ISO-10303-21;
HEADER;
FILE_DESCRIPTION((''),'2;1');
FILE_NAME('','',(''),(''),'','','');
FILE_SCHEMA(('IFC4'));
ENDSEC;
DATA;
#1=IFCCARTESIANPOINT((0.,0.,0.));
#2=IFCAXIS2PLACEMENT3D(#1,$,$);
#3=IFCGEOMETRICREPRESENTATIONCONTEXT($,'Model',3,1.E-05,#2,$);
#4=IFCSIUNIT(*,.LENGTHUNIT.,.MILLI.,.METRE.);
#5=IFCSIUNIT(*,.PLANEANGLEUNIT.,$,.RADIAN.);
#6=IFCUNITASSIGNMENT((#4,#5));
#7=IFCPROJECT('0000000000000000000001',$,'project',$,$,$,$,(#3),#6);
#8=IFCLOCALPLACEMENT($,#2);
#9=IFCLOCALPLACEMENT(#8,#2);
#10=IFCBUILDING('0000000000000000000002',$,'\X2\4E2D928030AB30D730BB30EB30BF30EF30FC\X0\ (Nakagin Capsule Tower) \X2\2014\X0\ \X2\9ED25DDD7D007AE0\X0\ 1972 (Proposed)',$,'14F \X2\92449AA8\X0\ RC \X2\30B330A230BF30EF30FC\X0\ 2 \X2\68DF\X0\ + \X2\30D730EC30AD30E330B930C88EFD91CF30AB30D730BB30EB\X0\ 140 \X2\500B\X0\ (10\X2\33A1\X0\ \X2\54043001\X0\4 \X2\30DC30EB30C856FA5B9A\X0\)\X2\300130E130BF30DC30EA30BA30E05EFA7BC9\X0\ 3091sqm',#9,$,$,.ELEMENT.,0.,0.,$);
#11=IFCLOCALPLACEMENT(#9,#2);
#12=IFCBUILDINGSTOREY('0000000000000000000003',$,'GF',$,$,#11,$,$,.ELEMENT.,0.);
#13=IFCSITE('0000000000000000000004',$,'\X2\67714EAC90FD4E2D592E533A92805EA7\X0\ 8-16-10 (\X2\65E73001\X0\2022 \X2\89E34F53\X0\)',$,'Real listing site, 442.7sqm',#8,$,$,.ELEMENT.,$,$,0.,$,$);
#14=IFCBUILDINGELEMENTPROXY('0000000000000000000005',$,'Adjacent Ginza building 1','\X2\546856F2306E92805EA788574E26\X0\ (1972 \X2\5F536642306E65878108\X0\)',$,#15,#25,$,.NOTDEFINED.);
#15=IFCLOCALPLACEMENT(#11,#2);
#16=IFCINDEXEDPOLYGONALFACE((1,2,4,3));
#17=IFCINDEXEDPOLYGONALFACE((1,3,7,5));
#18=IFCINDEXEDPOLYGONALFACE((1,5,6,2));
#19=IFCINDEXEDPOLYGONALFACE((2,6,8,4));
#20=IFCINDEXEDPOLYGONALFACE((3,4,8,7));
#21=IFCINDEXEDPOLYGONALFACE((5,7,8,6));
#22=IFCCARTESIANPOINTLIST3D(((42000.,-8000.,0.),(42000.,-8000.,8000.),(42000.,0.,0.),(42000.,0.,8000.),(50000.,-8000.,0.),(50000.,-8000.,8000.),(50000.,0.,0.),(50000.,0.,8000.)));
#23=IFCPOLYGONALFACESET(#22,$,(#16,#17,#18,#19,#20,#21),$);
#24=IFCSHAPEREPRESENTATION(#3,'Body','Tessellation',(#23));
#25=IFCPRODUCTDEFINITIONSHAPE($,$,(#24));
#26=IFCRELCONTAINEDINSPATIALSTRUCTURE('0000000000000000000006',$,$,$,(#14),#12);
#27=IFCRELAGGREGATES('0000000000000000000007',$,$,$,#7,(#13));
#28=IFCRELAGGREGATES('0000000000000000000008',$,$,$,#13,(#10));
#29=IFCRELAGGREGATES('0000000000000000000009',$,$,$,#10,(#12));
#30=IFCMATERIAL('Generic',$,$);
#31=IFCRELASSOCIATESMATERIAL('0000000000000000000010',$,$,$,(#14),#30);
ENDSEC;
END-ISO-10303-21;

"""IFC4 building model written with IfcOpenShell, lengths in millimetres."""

from ifc_helpers import new_model, si_unit, frame, frame_2d, origin, place, context, project, spatial, rectangle, extrude, material, element, save


model = new_model("IFC4")

# Units and contexts
model_context = context("Model", 3, precision=1e-05, world=origin())
ifc_project = project(units=[si_unit("LENGTHUNIT", "METRE", prefix="MILLI"), si_unit("PLANEANGLEUNIT", "RADIAN")], contexts=[model_context])

# Site, building, storey
site_placement = place(None, origin())
site = spatial("IfcSite", under=ifc_project, at=site_placement, Name="東京都中央区銀座 8-16-10 (旧、2022 解体)", ObjectType="Real listing site, 442.7sqm", CompositionType="ELEMENT", RefElevation=0.0)
building_placement = place(site_placement, origin())
building = spatial("IfcBuilding", under=site, at=building_placement, Name="中銀カプセルタワー (Nakagin Capsule Tower) — 黒川紀章 1972 (Proposed)", ObjectType="14F 鉄骨 RC コアタワー 2 棟 + プレキャスト軽量カプセル 140 個 (10㎡ 各、4 ボルト固定)、メタボリズム建築 3091sqm", CompositionType="ELEMENT", ElevationOfRefHeight=0.0, ElevationOfTerrain=0.0)
storey_placement = place(building_placement, origin())
storey = spatial("IfcBuildingStorey", under=building, at=storey_placement, Name="GF", CompositionType="ELEMENT", Elevation=0.0)

# Shared definitions
ifc_material_1 = material(Name="Generic")

# Building element proxy
proxy_1_placement = place(storey_placement, frame((21000.0, -4000.0, 0.0)))
element("IfcBuildingElementProxy", 1, at=proxy_1_placement, inside=storey, material=ifc_material_1, Name="Adjacent Ginza building 1", Description="周囲の銀座街並 (1972 当時の文脈)", PredefinedType="NOTDEFINED", context=model_context, shape_type="SweptSolid", body=[
    extrude(rectangle(XDim=8000.0, YDim=8000.0, at=frame_2d((4000.0, 4000.0))), frame((21000.0, -4000.0, 0.0)), (0.0, 0.0, 1.0), 8000.0),
])

save(model, "model.ifc")
